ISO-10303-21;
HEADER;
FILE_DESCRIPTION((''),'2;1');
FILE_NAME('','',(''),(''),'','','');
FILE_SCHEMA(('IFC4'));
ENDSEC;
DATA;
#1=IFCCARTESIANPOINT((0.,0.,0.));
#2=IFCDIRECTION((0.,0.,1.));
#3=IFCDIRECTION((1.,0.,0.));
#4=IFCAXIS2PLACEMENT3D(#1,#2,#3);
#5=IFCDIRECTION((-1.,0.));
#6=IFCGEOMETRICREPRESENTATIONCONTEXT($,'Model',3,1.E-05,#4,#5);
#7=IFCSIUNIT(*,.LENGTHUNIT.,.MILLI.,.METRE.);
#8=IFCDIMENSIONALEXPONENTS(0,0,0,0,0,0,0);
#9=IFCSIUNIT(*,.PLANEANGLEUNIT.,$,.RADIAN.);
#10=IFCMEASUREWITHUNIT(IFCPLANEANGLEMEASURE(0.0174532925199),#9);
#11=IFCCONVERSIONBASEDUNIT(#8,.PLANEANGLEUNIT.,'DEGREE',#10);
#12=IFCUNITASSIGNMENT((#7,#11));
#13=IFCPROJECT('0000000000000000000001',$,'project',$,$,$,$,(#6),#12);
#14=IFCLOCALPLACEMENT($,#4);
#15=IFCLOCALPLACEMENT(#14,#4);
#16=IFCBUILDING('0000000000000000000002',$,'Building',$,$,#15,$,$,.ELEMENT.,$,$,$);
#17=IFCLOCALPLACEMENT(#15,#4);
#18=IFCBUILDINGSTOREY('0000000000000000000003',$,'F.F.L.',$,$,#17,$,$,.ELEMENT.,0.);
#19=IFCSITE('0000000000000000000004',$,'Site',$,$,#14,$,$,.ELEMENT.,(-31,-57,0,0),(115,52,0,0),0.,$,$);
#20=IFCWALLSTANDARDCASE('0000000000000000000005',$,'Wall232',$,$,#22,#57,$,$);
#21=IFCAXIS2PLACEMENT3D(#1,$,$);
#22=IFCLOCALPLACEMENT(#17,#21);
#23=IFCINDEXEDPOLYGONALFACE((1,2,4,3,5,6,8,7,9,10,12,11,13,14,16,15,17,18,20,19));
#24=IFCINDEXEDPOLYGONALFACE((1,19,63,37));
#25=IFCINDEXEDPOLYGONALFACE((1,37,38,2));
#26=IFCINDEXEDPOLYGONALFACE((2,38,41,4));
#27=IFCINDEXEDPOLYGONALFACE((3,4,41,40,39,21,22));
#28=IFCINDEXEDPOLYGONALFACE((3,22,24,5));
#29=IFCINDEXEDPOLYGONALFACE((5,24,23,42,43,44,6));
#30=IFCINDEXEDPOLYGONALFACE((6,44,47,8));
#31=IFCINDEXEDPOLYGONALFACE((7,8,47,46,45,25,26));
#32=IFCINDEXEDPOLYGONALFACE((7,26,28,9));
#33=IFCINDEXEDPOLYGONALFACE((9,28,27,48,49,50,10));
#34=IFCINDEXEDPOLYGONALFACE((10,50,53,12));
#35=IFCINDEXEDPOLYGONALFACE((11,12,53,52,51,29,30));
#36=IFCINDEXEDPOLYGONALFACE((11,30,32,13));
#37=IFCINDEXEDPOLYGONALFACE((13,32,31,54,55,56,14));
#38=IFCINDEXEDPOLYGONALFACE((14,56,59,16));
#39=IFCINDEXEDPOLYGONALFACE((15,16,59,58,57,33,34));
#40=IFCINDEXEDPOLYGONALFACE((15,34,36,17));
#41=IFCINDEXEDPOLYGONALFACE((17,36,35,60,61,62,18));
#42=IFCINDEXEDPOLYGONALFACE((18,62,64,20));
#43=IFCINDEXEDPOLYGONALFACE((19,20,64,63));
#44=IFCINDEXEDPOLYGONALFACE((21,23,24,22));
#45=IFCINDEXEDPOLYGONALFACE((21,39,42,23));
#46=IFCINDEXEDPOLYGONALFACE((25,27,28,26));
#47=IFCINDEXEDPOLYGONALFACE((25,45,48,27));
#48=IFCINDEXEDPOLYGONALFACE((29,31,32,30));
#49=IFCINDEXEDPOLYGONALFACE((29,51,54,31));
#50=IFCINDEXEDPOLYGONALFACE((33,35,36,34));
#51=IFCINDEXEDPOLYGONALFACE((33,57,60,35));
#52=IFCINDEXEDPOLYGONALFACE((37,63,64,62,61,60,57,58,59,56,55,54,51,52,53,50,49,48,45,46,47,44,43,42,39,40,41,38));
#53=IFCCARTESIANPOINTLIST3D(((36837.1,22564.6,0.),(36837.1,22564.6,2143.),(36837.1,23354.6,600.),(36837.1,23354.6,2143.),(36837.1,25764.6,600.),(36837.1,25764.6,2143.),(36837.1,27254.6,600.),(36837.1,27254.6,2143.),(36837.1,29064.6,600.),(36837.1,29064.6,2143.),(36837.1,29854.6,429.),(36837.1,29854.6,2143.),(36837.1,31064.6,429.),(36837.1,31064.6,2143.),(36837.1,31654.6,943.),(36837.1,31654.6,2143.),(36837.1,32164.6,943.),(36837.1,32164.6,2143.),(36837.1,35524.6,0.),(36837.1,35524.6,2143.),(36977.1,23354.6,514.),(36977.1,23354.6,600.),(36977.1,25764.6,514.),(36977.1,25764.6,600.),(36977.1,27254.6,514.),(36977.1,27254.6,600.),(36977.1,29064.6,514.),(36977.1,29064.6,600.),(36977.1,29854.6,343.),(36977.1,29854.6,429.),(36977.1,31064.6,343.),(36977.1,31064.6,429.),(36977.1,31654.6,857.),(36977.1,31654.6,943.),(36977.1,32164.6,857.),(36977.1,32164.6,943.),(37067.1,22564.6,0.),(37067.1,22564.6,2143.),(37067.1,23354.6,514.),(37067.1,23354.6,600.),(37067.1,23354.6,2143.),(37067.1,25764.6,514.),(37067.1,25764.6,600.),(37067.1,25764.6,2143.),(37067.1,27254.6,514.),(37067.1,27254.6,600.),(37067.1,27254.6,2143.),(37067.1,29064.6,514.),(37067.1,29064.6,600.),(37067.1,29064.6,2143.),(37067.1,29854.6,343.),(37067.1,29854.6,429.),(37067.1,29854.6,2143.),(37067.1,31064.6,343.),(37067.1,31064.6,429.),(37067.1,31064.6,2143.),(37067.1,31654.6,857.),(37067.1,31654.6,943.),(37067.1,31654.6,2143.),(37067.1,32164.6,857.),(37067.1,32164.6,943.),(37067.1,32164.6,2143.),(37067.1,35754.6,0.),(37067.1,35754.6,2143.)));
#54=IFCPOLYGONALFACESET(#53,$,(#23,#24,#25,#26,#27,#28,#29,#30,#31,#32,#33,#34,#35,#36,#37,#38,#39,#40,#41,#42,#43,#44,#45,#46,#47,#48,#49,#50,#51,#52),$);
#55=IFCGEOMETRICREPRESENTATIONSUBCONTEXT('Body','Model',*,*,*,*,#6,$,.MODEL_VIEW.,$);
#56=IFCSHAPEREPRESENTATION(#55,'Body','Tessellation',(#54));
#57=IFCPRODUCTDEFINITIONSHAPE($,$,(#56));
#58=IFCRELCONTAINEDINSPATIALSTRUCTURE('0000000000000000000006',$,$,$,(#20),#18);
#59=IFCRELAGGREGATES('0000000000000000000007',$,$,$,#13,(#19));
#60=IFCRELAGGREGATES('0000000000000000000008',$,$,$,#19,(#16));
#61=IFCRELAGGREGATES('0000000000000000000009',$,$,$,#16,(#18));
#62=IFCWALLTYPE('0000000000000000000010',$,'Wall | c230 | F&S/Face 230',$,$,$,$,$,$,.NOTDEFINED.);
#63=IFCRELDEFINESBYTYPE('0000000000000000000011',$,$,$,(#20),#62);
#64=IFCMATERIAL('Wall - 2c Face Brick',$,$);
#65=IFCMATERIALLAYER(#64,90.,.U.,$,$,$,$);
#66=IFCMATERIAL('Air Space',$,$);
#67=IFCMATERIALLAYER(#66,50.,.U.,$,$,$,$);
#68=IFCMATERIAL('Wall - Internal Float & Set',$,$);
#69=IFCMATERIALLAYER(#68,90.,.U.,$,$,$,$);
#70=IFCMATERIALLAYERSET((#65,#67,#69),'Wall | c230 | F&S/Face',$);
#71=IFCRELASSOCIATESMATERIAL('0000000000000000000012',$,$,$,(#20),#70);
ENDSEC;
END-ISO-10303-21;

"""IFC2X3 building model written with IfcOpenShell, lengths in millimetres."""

from ifc_helpers import new_model, entity, si_unit, converted_unit, direction, frame, origin_with_axes, origin_2d_with_axis, place, context, subcontext, project, spatial, polyline, rectangle, outline, extrude, material, layer, layer_set, layer_usage, type_object, element, save


model = new_model("IFC2X3")

# Units and contexts
model_context = context("Model", 3, precision=1e-05, world=origin_with_axes(), true_north=direction((-1.0, 0.0)))
body_context = subcontext(model_context, "Body", "Model", "MODEL_VIEW")
ifc_project = project(units=[si_unit("LENGTHUNIT", "METRE", prefix="MILLI"), converted_unit("PLANEANGLEUNIT", "DEGREE", entity("IfcPlaneAngleMeasure", 0.0174532925199), si_unit("PLANEANGLEUNIT", "RADIAN"), dimensions=[0, 0, 0, 0, 0, 0, 0])], contexts=[model_context])

# Site, building, storey
site_placement = place(None, origin_with_axes())
site = spatial("IfcSite", under=ifc_project, at=site_placement, Name="Site", CompositionType="ELEMENT", RefLatitude=(-31, -57, 0, 0), RefLongitude=(115, 52, 0, 0), RefElevation=0.0)
building_placement = place(site_placement, origin_with_axes())
building = spatial("IfcBuilding", under=site, at=building_placement, Name="Building", CompositionType="ELEMENT")
storey_placement = place(building_placement, origin_with_axes())
storey = spatial("IfcBuildingStorey", under=building, at=storey_placement, Name="F.F.L.", CompositionType="ELEMENT", Elevation=0.0)

# Shared definitions
ifc_material_1 = material(Name="Wall - Internal Float & Set")

# Shared definitions
ifc_material_2 = material(Name="Wall - 2c Face Brick")
ifc_layer_1 = layer(ifc_material_2, 90.0, ventilated="UNKNOWN")
ifc_material_3 = material(Name="Air Space")
ifc_layer_2 = layer(ifc_material_3, 50.0, ventilated="UNKNOWN")
ifc_layer_3 = layer(ifc_material_1, 90.0, ventilated="UNKNOWN")
ifc_layer_set_1 = layer_set([ifc_layer_1, ifc_layer_2, ifc_layer_3], Name="Wall | c230 | F&S/Face")
wall_type_1 = type_object("IfcWallType", Name="Wall | c230 | F&S/Face 230", PredefinedType="NOTDEFINED")

# Wall, openings
ifc_layer_usage_1 = layer_usage(ifc_layer_set_1, "AXIS2", "NEGATIVE", 0.0)
wall_1_placement = place(storey_placement, frame((37067.1, 35754.6, 0.0), z_axis=(0.0, 0.0, 1.0), x_axis=(0.0, -1.0, 0.0)))
wall_1 = element("IfcWallStandardCase", 1, at=wall_1_placement, inside=storey, type_object=wall_type_1, material=ifc_layer_usage_1, Name="Wall232", context=body_context, shape_type="SweptSolid", body=[
    extrude(outline(polyline([(230.0, -230.0), (13190.0, -230.0), (13190.0, 0.0), (0.0, 0.0), (230.0, -230.0)])), origin_with_axes(), (0.0, 0.0, 1.0), 2143.0),
])
opening_1_placement = place(wall_1_placement, frame((11195.0, 0.0, 600.0), z_axis=(0.0, 0.0, 1.0), x_axis=(1.0, 0.0, 0.0)))
element("IfcOpeningElement", 2, at=opening_1_placement, cuts=wall_1, context=body_context, shape_type="SweptSolid", body=[
    extrude(rectangle(XDim=2410.0, YDim=1543.0, at=origin_2d_with_axis()), frame((0.0, 15070.0, 771.5), z_axis=(0.0, -1.0, 0.0), x_axis=(-1.0, 0.0, 0.0)), (0.0, 0.0, 1.0), 15380.0),
    extrude(outline(polyline([(-1205.0, -86.0), (1205.0, -86.0), (1205.0, 0.0), (-1205.0, 0.0), (-1205.0, -86.0)])), frame((0.0, 2050.0, 0.0), z_axis=(0.0, 1.0, 0.0), x_axis=(-1.0, 0.0, 0.0)), (0.0, 0.0, -1.0), 2140.0),
    extrude(rectangle(XDim=2410.0, YDim=1543.0, at=origin_2d_with_axis()), frame((0.0, -80.0, 771.5), z_axis=(0.0, 1.0, 0.0), x_axis=(-1.0, 0.0, 0.0)), (0.0, 0.0, 1.0), 310.0),
])
opening_2_placement = place(wall_1_placement, frame((7595.0, 0.0, 600.0), z_axis=(0.0, 0.0, 1.0), x_axis=(1.0, 0.0, 0.0)))
element("IfcOpeningElement", 3, at=opening_2_placement, cuts=wall_1, context=body_context, shape_type="SweptSolid", body=[
    extrude(rectangle(XDim=1810.0, YDim=1543.0, at=origin_2d_with_axis()), frame((0.0, 15070.0, 771.5), z_axis=(0.0, 1.0, 0.0), x_axis=(1.0, 0.0, 0.0)), (0.0, 0.0, -1.0), 15380.0),
    extrude(outline(polyline([(-905.0, -86.0), (905.0, -86.0), (905.0, 0.0), (-905.0, 0.0), (-905.0, -86.0)])), frame((0.0, 2050.0, 0.0), z_axis=(0.0, -1.0, 0.0), x_axis=(1.0, 0.0, 0.0)), (0.0, 0.0, 1.0), 2140.0),
    extrude(rectangle(XDim=1810.0, YDim=1543.0, at=origin_2d_with_axis()), frame((0.0, -80.0, 771.5), z_axis=(0.0, -1.0, 0.0), x_axis=(1.0, 0.0, 0.0)), (0.0, 0.0, -1.0), 310.0),
])
opening_3_placement = place(wall_1_placement, frame((5295.0, 0.0, 429.0), z_axis=(0.0, 0.0, 1.0), x_axis=(1.0, 0.0, 0.0)))
element("IfcOpeningElement", 4, at=opening_3_placement, cuts=wall_1, context=body_context, shape_type="SweptSolid", body=[
    extrude(rectangle(XDim=1210.0, YDim=1714.0, at=origin_2d_with_axis()), frame((0.0, 15070.0, 857.0), z_axis=(0.0, -1.0, 0.0), x_axis=(-1.0, 0.0, 0.0)), (0.0, 0.0, 1.0), 15380.0),
    extrude(outline(polyline([(-605.0, -86.0), (605.0, -86.0), (605.0, 0.0), (-605.0, 0.0), (-605.0, -86.0)])), frame((0.0, 2050.0, 0.0), z_axis=(0.0, 1.0, 0.0), x_axis=(-1.0, 0.0, 0.0)), (0.0, 0.0, -1.0), 2140.0),
    extrude(rectangle(XDim=1210.0, YDim=1714.0, at=origin_2d_with_axis()), frame((0.0, -80.0, 857.0), z_axis=(0.0, 1.0, 0.0), x_axis=(-1.0, 0.0, 0.0)), (0.0, 0.0, 1.0), 310.0),
])
opening_4_placement = place(wall_1_placement, frame((3845.0, 0.0, 943.0), z_axis=(0.0, 0.0, 1.0), x_axis=(1.0, 0.0, 0.0)))
element("IfcOpeningElement", 5, at=opening_4_placement, cuts=wall_1, context=body_context, shape_type="SweptSolid", body=[
    extrude(rectangle(XDim=510.0, YDim=1200.0, at=origin_2d_with_axis()), frame((0.0, 15070.0, 600.0), z_axis=(0.0, 1.0, 0.0), x_axis=(1.0, 0.0, 0.0)), (0.0, 0.0, -1.0), 15380.0),
    extrude(outline(polyline([(-255.0, -86.0), (255.0, -86.0), (255.0, 0.0), (-255.0, 0.0), (-255.0, -86.0)])), frame((0.0, 2050.0, 0.0), z_axis=(0.0, -1.0, 0.0), x_axis=(1.0, 0.0, 0.0)), (0.0, 0.0, 1.0), 2140.0),
    extrude(rectangle(XDim=510.0, YDim=1200.0, at=origin_2d_with_axis()), frame((0.0, -80.0, 600.0), z_axis=(0.0, -1.0, 0.0), x_axis=(1.0, 0.0, 0.0)), (0.0, 0.0, -1.0), 310.0),
])

save(model, "model.ifc")
